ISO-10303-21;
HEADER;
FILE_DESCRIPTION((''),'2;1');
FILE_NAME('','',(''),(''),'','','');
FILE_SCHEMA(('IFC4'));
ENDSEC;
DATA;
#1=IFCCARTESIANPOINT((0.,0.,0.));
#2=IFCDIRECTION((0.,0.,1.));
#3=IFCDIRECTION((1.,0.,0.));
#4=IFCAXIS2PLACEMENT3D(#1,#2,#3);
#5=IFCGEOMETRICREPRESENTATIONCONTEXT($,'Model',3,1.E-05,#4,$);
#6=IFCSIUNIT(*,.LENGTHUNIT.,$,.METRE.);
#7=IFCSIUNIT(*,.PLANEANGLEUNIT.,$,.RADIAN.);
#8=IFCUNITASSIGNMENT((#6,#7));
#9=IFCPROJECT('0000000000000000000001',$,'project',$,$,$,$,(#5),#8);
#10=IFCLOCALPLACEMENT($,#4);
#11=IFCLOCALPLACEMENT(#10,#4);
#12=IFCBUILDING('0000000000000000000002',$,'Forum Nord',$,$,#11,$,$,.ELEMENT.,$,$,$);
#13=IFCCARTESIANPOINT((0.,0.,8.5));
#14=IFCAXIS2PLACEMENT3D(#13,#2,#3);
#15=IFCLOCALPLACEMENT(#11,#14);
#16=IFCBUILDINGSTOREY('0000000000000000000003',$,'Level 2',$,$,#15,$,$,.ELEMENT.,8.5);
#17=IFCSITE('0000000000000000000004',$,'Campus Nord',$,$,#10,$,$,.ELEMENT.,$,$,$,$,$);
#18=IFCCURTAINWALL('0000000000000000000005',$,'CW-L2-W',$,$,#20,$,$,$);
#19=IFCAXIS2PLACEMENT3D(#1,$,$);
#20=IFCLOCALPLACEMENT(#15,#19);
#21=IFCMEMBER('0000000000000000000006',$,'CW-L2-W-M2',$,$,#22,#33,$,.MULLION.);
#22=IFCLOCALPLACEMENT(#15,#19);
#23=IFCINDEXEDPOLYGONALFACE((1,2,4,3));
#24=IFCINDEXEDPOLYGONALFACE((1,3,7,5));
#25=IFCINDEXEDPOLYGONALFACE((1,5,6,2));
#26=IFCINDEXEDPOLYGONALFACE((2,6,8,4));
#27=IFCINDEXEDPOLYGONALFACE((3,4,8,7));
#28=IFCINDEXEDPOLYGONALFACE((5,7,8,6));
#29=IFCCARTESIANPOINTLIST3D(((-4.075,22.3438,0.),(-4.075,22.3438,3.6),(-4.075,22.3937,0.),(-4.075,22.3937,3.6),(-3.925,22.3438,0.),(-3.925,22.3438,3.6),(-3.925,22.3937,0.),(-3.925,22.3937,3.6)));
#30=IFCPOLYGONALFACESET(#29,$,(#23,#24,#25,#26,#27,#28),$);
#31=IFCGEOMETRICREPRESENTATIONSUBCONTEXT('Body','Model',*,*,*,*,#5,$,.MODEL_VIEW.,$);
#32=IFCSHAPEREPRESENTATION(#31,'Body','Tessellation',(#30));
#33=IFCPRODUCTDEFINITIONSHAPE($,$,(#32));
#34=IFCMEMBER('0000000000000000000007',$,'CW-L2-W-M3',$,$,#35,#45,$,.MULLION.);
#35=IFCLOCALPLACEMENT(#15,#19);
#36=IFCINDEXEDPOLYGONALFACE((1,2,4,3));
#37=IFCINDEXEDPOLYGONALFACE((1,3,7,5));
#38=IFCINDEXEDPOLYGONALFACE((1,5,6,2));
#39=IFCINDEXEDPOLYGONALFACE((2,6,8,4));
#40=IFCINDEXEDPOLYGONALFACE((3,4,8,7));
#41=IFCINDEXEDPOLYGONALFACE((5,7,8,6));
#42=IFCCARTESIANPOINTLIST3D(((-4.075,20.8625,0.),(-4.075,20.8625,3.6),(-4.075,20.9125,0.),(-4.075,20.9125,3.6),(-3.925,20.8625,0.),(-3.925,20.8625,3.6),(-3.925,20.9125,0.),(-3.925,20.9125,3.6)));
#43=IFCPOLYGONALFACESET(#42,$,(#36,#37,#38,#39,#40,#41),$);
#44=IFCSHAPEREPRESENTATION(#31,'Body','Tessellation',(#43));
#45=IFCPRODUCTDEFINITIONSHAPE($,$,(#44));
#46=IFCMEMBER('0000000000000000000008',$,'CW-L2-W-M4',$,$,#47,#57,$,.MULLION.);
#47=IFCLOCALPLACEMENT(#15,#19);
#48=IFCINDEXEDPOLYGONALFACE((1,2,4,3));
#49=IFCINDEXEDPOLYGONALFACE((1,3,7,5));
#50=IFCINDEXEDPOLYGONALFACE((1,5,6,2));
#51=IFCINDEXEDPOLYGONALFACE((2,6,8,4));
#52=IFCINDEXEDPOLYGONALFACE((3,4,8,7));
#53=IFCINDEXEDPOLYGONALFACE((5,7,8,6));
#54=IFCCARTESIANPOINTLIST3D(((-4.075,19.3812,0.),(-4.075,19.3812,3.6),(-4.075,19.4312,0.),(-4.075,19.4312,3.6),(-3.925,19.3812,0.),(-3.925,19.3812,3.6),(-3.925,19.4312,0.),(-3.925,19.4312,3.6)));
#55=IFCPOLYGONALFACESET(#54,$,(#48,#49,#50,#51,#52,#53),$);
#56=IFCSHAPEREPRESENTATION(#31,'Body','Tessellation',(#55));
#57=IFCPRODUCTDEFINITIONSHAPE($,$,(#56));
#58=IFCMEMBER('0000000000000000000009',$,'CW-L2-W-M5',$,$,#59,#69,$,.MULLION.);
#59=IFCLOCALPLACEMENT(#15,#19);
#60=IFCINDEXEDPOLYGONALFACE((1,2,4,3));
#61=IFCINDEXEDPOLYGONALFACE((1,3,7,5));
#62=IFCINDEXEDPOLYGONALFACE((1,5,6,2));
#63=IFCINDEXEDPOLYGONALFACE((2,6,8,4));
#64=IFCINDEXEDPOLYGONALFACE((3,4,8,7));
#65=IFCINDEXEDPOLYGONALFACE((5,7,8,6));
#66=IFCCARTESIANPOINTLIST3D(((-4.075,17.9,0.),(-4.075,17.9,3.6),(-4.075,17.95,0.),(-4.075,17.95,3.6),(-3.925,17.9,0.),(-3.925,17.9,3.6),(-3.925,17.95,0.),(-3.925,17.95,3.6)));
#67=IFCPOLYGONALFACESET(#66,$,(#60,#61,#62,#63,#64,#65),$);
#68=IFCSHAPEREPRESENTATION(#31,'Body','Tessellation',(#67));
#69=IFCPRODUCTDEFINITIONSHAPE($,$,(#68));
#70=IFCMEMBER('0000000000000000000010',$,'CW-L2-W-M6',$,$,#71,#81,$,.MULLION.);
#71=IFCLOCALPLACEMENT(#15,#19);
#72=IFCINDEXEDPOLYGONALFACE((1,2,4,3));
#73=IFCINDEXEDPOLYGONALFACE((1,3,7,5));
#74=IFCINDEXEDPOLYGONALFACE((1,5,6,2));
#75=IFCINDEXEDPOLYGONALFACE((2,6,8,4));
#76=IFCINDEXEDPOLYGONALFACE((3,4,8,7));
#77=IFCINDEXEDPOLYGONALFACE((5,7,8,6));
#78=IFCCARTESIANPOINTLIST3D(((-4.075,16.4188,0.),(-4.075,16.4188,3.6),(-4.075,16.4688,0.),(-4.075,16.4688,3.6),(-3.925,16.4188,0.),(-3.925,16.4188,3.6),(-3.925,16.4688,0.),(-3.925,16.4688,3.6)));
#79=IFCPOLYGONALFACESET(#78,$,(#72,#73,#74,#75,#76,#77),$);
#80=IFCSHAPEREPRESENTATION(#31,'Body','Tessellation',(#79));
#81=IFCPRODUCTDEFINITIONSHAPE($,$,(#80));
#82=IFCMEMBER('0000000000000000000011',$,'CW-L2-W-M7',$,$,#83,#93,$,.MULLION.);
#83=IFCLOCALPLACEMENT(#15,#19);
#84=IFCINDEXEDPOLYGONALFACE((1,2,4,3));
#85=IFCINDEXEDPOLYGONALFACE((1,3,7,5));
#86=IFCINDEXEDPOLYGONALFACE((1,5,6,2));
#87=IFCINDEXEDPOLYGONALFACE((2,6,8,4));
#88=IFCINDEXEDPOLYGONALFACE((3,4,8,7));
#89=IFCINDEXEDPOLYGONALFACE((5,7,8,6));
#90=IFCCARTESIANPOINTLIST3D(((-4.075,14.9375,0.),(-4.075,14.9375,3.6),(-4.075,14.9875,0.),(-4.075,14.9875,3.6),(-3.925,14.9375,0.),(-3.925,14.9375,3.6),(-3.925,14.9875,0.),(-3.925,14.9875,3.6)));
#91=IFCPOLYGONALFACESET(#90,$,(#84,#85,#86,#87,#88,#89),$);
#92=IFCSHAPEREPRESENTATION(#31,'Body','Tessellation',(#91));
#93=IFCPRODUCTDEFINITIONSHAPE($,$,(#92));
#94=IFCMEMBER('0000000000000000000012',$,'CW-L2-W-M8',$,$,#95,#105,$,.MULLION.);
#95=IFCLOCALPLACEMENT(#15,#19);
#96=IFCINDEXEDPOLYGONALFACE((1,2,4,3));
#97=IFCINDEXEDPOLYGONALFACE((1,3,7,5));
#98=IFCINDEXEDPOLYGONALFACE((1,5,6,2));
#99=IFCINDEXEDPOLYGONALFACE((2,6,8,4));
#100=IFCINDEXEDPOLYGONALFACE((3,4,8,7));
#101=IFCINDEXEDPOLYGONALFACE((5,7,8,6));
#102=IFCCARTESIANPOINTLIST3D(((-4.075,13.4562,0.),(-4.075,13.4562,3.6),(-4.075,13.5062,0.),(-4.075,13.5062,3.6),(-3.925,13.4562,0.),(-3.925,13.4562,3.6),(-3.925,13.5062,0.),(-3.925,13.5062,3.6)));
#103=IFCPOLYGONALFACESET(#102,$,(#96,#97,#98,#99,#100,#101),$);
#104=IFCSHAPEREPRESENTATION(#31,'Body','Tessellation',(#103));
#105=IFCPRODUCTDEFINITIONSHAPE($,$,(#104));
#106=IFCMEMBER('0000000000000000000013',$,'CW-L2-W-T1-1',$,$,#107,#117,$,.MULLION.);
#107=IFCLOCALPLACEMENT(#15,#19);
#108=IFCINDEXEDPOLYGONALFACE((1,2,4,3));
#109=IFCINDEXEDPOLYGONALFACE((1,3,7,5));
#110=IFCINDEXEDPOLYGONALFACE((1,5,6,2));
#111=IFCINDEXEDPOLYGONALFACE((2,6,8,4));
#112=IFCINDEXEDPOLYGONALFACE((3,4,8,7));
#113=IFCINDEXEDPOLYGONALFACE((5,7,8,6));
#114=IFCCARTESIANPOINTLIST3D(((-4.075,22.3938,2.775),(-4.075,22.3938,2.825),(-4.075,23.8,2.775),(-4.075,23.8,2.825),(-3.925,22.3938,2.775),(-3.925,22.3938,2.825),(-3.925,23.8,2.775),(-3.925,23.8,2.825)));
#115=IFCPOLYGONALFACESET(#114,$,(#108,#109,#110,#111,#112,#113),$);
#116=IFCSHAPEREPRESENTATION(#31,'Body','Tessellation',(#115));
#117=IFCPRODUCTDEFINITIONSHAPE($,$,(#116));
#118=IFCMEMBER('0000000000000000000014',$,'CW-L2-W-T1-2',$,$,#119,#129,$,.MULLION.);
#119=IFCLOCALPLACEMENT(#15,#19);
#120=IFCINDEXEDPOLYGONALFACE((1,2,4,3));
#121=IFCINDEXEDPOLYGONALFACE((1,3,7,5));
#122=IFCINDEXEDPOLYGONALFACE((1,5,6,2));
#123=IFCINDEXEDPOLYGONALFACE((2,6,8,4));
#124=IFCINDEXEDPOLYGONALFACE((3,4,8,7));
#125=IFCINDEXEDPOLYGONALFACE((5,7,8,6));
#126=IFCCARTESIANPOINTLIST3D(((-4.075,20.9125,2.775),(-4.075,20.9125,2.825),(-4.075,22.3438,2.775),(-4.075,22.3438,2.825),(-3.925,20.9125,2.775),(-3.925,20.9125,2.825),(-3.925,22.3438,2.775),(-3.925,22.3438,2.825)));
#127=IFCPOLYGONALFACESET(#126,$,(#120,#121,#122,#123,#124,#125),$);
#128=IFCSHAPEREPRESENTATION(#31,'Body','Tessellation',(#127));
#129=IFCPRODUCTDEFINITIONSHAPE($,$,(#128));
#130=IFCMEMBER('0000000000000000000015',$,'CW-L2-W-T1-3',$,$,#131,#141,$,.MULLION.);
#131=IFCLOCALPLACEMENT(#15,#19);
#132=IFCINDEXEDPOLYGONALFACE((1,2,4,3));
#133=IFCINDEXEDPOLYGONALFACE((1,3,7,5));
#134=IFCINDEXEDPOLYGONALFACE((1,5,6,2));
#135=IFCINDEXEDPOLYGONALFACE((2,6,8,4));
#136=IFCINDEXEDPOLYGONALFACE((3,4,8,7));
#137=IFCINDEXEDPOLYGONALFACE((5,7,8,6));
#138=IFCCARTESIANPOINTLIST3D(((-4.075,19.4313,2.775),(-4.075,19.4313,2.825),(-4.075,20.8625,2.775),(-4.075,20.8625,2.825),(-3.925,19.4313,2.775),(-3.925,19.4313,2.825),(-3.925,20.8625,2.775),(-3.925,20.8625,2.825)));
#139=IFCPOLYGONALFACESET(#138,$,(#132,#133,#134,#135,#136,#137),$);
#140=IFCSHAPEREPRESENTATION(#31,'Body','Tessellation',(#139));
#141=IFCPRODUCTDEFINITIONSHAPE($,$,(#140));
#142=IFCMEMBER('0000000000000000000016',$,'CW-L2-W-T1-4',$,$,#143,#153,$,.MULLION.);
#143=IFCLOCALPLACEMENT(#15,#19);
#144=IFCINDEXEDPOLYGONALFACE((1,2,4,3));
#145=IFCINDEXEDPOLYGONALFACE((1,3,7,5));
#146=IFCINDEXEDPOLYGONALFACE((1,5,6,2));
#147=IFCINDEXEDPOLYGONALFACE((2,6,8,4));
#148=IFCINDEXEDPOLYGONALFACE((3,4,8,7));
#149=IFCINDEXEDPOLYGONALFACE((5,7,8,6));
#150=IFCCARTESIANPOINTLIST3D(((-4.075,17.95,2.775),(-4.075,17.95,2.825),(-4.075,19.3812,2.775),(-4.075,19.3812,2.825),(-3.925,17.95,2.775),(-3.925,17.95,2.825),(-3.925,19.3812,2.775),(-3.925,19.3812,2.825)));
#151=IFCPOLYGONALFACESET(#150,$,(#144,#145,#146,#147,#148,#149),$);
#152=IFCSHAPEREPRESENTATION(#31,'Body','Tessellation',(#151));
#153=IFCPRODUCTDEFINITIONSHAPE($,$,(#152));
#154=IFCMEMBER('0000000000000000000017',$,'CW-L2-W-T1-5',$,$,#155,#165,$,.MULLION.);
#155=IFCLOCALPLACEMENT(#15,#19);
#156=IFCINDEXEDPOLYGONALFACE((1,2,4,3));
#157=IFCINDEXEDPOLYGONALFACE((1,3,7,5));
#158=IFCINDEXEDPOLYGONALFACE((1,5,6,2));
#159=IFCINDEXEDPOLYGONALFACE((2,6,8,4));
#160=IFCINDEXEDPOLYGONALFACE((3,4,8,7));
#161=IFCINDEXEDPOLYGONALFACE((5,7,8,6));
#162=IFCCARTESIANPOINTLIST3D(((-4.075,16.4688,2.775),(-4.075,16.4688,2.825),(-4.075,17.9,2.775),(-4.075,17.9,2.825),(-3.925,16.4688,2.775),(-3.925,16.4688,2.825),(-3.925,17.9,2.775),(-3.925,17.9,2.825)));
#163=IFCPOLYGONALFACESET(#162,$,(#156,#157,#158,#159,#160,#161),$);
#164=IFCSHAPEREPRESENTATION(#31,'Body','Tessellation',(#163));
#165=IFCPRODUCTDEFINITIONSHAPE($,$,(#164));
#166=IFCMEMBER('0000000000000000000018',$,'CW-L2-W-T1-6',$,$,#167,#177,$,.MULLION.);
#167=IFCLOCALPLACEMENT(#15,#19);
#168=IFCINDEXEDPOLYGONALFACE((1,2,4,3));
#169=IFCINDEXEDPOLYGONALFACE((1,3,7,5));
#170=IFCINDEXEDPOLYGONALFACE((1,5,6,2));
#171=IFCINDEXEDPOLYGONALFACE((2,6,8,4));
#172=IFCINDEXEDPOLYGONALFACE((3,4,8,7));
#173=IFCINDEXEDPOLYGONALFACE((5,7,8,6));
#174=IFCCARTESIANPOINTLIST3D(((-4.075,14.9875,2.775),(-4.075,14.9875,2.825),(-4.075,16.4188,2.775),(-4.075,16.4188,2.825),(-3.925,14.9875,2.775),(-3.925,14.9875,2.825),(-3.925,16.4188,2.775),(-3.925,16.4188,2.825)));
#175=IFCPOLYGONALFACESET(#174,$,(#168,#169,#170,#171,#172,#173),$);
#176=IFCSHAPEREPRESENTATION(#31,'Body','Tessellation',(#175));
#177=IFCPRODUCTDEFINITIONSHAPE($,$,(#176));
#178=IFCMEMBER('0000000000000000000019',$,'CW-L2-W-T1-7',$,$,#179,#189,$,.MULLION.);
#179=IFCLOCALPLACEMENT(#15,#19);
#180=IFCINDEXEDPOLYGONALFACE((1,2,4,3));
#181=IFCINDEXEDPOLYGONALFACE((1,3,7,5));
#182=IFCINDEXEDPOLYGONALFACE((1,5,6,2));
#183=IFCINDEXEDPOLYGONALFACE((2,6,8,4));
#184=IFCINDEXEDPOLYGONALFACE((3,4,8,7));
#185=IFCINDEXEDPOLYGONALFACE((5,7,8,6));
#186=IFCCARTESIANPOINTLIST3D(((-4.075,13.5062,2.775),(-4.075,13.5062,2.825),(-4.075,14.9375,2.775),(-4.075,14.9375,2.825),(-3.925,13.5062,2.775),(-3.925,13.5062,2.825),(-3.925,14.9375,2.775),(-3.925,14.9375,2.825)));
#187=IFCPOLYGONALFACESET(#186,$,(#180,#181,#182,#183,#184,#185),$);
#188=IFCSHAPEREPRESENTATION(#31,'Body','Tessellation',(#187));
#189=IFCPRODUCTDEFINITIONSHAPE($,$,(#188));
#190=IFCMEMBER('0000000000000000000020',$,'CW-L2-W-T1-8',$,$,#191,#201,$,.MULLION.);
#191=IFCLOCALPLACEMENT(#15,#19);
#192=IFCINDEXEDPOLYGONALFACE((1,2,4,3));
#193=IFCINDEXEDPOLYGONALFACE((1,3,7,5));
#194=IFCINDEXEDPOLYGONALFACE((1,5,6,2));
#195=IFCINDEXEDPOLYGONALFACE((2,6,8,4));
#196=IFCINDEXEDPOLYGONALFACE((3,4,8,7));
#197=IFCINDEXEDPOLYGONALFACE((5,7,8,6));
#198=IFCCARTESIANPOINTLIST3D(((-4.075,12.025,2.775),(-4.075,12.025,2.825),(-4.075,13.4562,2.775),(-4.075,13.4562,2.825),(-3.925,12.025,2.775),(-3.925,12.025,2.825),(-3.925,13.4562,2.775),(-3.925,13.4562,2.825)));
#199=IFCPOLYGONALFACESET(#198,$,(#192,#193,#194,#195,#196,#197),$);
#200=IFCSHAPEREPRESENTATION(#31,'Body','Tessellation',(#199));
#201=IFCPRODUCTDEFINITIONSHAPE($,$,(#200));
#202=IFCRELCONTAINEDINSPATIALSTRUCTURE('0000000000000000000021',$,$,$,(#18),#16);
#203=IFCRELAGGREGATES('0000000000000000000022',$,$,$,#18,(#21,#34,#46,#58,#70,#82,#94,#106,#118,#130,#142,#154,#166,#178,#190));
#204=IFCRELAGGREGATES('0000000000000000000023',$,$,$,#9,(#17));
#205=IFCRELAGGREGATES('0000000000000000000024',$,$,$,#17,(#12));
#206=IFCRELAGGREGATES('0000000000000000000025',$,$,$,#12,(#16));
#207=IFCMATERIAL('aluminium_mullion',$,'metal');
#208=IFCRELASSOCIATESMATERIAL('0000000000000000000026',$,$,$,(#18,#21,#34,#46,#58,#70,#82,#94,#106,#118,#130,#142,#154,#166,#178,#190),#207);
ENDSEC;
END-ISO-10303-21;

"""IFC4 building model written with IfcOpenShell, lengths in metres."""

from ifc_helpers import new_model, si_unit, frame, origin_with_axes, origin_2d_with_axis, place, context, subcontext, project, spatial, rectangle, extrude, material, element, aggregate, save


model = new_model("IFC4")

# Units and contexts
model_context = context("Model", 3, precision=1e-05, world=origin_with_axes())
body_context = subcontext(model_context, "Body", "Model", "MODEL_VIEW")
ifc_project = project(units=[si_unit("LENGTHUNIT", "METRE"), si_unit("PLANEANGLEUNIT", "RADIAN")], contexts=[model_context])

# Site, building, storey
site_placement = place(None, origin_with_axes())
site = spatial("IfcSite", under=ifc_project, at=site_placement, Name="Campus Nord", CompositionType="ELEMENT")
building_placement = place(site_placement, origin_with_axes())
building = spatial("IfcBuilding", under=site, at=building_placement, Name="Forum Nord", CompositionType="ELEMENT")
storey_placement = place(building_placement, frame((0.0, 0.0, 8.5), z_axis=(0.0, 0.0, 1.0), x_axis=(1.0, 0.0, 0.0)))
storey = spatial("IfcBuildingStorey", under=building, at=storey_placement, Name="Level 2", CompositionType="ELEMENT", Elevation=8.5)

# Curtain wall, members
ifc_material_1 = material(Name="aluminium_mullion", Category="metal")
curtain_wall_placement = place(storey_placement, origin_with_axes())
curtain_wall = element("IfcCurtainWall", 1, at=curtain_wall_placement, inside=storey, material=ifc_material_1, Name="CW-L2-W")
member_1_placement = place(storey_placement, frame((-4.0, 22.3687, 0.0), z_axis=(0.0, 0.0, 1.0), x_axis=(0.0, -1.0, 0.0)))
member_1 = element("IfcMember", 2, at=member_1_placement, material=ifc_material_1, Name="CW-L2-W-M2", PredefinedType="MULLION", context=body_context, shape_type="SweptSolid", body=[
    extrude(rectangle(XDim=0.05, YDim=0.15, at=origin_2d_with_axis()), origin_with_axes(), (0.0, 0.0, 1.0), 3.6),
])
member_2_placement = place(storey_placement, frame((-4.0, 20.8875, 0.0), z_axis=(0.0, 0.0, 1.0), x_axis=(0.0, -1.0, 0.0)))
member_2 = element("IfcMember", 3, at=member_2_placement, material=ifc_material_1, Name="CW-L2-W-M3", PredefinedType="MULLION", context=body_context, shape_type="SweptSolid", body=[
    extrude(rectangle(XDim=0.05, YDim=0.15, at=origin_2d_with_axis()), origin_with_axes(), (0.0, 0.0, 1.0), 3.6),
])
member_3_placement = place(storey_placement, frame((-4.0, 19.4062, 0.0), z_axis=(0.0, 0.0, 1.0), x_axis=(0.0, -1.0, 0.0)))
member_3 = element("IfcMember", 4, at=member_3_placement, material=ifc_material_1, Name="CW-L2-W-M4", PredefinedType="MULLION", context=body_context, shape_type="SweptSolid", body=[
    extrude(rectangle(XDim=0.05, YDim=0.15, at=origin_2d_with_axis()), origin_with_axes(), (0.0, 0.0, 1.0), 3.6),
])
member_4_placement = place(storey_placement, frame((-4.0, 17.925, 0.0), z_axis=(0.0, 0.0, 1.0), x_axis=(0.0, -1.0, 0.0)))
member_4 = element("IfcMember", 5, at=member_4_placement, material=ifc_material_1, Name="CW-L2-W-M5", PredefinedType="MULLION", context=body_context, shape_type="SweptSolid", body=[
    extrude(rectangle(XDim=0.05, YDim=0.15, at=origin_2d_with_axis()), origin_with_axes(), (0.0, 0.0, 1.0), 3.6),
])
member_5_placement = place(storey_placement, frame((-4.0, 16.4438, 0.0), z_axis=(0.0, 0.0, 1.0), x_axis=(0.0, -1.0, 0.0)))
member_5 = element("IfcMember", 6, at=member_5_placement, material=ifc_material_1, Name="CW-L2-W-M6", PredefinedType="MULLION", context=body_context, shape_type="SweptSolid", body=[
    extrude(rectangle(XDim=0.05, YDim=0.15, at=origin_2d_with_axis()), origin_with_axes(), (0.0, 0.0, 1.0), 3.6),
])
member_6_placement = place(storey_placement, frame((-4.0, 14.9625, 0.0), z_axis=(0.0, 0.0, 1.0), x_axis=(0.0, -1.0, 0.0)))
member_6 = element("IfcMember", 7, at=member_6_placement, material=ifc_material_1, Name="CW-L2-W-M7", PredefinedType="MULLION", context=body_context, shape_type="SweptSolid", body=[
    extrude(rectangle(XDim=0.05, YDim=0.15, at=origin_2d_with_axis()), origin_with_axes(), (0.0, 0.0, 1.0), 3.6),
])
member_7_placement = place(storey_placement, frame((-4.0, 13.4812, 0.0), z_axis=(0.0, 0.0, 1.0), x_axis=(0.0, -1.0, 0.0)))
member_7 = element("IfcMember", 8, at=member_7_placement, material=ifc_material_1, Name="CW-L2-W-M8", PredefinedType="MULLION", context=body_context, shape_type="SweptSolid", body=[
    extrude(rectangle(XDim=0.05, YDim=0.15, at=origin_2d_with_axis()), origin_with_axes(), (0.0, 0.0, 1.0), 3.6),
])
member_8_placement = place(storey_placement, frame((-4.0, 23.8, 2.8), z_axis=(0.0, -1.0, 0.0), x_axis=(1.0, 0.0, 0.0)))
member_8 = element("IfcMember", 9, at=member_8_placement, material=ifc_material_1, Name="CW-L2-W-T1-1", PredefinedType="MULLION", context=body_context, shape_type="SweptSolid", body=[
    extrude(rectangle(XDim=0.15, YDim=0.05, at=origin_2d_with_axis()), origin_with_axes(), (0.0, 0.0, 1.0), 1.4062),
])
member_9_placement = place(storey_placement, frame((-4.0, 22.3438, 2.8), z_axis=(0.0, -1.0, 0.0), x_axis=(1.0, 0.0, 0.0)))
member_9 = element("IfcMember", 10, at=member_9_placement, material=ifc_material_1, Name="CW-L2-W-T1-2", PredefinedType="MULLION", context=body_context, shape_type="SweptSolid", body=[
    extrude(rectangle(XDim=0.15, YDim=0.05, at=origin_2d_with_axis()), origin_with_axes(), (0.0, 0.0, 1.0), 1.4312),
])
member_10_placement = place(storey_placement, frame((-4.0, 20.8625, 2.8), z_axis=(0.0, -1.0, 0.0), x_axis=(1.0, 0.0, 0.0)))
member_10 = element("IfcMember", 11, at=member_10_placement, material=ifc_material_1, Name="CW-L2-W-T1-3", PredefinedType="MULLION", context=body_context, shape_type="SweptSolid", body=[
    extrude(rectangle(XDim=0.15, YDim=0.05, at=origin_2d_with_axis()), origin_with_axes(), (0.0, 0.0, 1.0), 1.4312),
])
member_11_placement = place(storey_placement, frame((-4.0, 19.3813, 2.8), z_axis=(0.0, -1.0, 0.0), x_axis=(1.0, 0.0, 0.0)))
member_11 = element("IfcMember", 12, at=member_11_placement, material=ifc_material_1, Name="CW-L2-W-T1-4", PredefinedType="MULLION", context=body_context, shape_type="SweptSolid", body=[
    extrude(rectangle(XDim=0.15, YDim=0.05, at=origin_2d_with_axis()), origin_with_axes(), (0.0, 0.0, 1.0), 1.4312),
])
member_12_placement = place(storey_placement, frame((-4.0, 17.9, 2.8), z_axis=(0.0, -1.0, 0.0), x_axis=(1.0, 0.0, 0.0)))
member_12 = element("IfcMember", 13, at=member_12_placement, material=ifc_material_1, Name="CW-L2-W-T1-5", PredefinedType="MULLION", context=body_context, shape_type="SweptSolid", body=[
    extrude(rectangle(XDim=0.15, YDim=0.05, at=origin_2d_with_axis()), origin_with_axes(), (0.0, 0.0, 1.0), 1.4312),
])
member_13_placement = place(storey_placement, frame((-4.0, 16.4187, 2.8), z_axis=(0.0, -1.0, 0.0), x_axis=(1.0, 0.0, 0.0)))
member_13 = element("IfcMember", 14, at=member_13_placement, material=ifc_material_1, Name="CW-L2-W-T1-6", PredefinedType="MULLION", context=body_context, shape_type="SweptSolid", body=[
    extrude(rectangle(XDim=0.15, YDim=0.05, at=origin_2d_with_axis()), origin_with_axes(), (0.0, 0.0, 1.0), 1.4312),
])
member_14_placement = place(storey_placement, frame((-4.0, 14.9375, 2.8), z_axis=(0.0, -1.0, 0.0), x_axis=(1.0, 0.0, 0.0)))
member_14 = element("IfcMember", 15, at=member_14_placement, material=ifc_material_1, Name="CW-L2-W-T1-7", PredefinedType="MULLION", context=body_context, shape_type="SweptSolid", body=[
    extrude(rectangle(XDim=0.15, YDim=0.05, at=origin_2d_with_axis()), origin_with_axes(), (0.0, 0.0, 1.0), 1.4312),
])
member_15_placement = place(storey_placement, frame((-4.0, 13.4563, 2.8), z_axis=(0.0, -1.0, 0.0), x_axis=(1.0, 0.0, 0.0)))
member_15 = element("IfcMember", 16, at=member_15_placement, material=ifc_material_1, Name="CW-L2-W-T1-8", PredefinedType="MULLION", context=body_context, shape_type="SweptSolid", body=[
    extrude(rectangle(XDim=0.15, YDim=0.05, at=origin_2d_with_axis()), origin_with_axes(), (0.0, 0.0, 1.0), 1.4312),
])
aggregate(curtain_wall, [member_1, member_2, member_3, member_4, member_5, member_6, member_7, member_8, member_9, member_10, member_11, member_12, member_13, member_14, member_15])

save(model, "model.ifc")
